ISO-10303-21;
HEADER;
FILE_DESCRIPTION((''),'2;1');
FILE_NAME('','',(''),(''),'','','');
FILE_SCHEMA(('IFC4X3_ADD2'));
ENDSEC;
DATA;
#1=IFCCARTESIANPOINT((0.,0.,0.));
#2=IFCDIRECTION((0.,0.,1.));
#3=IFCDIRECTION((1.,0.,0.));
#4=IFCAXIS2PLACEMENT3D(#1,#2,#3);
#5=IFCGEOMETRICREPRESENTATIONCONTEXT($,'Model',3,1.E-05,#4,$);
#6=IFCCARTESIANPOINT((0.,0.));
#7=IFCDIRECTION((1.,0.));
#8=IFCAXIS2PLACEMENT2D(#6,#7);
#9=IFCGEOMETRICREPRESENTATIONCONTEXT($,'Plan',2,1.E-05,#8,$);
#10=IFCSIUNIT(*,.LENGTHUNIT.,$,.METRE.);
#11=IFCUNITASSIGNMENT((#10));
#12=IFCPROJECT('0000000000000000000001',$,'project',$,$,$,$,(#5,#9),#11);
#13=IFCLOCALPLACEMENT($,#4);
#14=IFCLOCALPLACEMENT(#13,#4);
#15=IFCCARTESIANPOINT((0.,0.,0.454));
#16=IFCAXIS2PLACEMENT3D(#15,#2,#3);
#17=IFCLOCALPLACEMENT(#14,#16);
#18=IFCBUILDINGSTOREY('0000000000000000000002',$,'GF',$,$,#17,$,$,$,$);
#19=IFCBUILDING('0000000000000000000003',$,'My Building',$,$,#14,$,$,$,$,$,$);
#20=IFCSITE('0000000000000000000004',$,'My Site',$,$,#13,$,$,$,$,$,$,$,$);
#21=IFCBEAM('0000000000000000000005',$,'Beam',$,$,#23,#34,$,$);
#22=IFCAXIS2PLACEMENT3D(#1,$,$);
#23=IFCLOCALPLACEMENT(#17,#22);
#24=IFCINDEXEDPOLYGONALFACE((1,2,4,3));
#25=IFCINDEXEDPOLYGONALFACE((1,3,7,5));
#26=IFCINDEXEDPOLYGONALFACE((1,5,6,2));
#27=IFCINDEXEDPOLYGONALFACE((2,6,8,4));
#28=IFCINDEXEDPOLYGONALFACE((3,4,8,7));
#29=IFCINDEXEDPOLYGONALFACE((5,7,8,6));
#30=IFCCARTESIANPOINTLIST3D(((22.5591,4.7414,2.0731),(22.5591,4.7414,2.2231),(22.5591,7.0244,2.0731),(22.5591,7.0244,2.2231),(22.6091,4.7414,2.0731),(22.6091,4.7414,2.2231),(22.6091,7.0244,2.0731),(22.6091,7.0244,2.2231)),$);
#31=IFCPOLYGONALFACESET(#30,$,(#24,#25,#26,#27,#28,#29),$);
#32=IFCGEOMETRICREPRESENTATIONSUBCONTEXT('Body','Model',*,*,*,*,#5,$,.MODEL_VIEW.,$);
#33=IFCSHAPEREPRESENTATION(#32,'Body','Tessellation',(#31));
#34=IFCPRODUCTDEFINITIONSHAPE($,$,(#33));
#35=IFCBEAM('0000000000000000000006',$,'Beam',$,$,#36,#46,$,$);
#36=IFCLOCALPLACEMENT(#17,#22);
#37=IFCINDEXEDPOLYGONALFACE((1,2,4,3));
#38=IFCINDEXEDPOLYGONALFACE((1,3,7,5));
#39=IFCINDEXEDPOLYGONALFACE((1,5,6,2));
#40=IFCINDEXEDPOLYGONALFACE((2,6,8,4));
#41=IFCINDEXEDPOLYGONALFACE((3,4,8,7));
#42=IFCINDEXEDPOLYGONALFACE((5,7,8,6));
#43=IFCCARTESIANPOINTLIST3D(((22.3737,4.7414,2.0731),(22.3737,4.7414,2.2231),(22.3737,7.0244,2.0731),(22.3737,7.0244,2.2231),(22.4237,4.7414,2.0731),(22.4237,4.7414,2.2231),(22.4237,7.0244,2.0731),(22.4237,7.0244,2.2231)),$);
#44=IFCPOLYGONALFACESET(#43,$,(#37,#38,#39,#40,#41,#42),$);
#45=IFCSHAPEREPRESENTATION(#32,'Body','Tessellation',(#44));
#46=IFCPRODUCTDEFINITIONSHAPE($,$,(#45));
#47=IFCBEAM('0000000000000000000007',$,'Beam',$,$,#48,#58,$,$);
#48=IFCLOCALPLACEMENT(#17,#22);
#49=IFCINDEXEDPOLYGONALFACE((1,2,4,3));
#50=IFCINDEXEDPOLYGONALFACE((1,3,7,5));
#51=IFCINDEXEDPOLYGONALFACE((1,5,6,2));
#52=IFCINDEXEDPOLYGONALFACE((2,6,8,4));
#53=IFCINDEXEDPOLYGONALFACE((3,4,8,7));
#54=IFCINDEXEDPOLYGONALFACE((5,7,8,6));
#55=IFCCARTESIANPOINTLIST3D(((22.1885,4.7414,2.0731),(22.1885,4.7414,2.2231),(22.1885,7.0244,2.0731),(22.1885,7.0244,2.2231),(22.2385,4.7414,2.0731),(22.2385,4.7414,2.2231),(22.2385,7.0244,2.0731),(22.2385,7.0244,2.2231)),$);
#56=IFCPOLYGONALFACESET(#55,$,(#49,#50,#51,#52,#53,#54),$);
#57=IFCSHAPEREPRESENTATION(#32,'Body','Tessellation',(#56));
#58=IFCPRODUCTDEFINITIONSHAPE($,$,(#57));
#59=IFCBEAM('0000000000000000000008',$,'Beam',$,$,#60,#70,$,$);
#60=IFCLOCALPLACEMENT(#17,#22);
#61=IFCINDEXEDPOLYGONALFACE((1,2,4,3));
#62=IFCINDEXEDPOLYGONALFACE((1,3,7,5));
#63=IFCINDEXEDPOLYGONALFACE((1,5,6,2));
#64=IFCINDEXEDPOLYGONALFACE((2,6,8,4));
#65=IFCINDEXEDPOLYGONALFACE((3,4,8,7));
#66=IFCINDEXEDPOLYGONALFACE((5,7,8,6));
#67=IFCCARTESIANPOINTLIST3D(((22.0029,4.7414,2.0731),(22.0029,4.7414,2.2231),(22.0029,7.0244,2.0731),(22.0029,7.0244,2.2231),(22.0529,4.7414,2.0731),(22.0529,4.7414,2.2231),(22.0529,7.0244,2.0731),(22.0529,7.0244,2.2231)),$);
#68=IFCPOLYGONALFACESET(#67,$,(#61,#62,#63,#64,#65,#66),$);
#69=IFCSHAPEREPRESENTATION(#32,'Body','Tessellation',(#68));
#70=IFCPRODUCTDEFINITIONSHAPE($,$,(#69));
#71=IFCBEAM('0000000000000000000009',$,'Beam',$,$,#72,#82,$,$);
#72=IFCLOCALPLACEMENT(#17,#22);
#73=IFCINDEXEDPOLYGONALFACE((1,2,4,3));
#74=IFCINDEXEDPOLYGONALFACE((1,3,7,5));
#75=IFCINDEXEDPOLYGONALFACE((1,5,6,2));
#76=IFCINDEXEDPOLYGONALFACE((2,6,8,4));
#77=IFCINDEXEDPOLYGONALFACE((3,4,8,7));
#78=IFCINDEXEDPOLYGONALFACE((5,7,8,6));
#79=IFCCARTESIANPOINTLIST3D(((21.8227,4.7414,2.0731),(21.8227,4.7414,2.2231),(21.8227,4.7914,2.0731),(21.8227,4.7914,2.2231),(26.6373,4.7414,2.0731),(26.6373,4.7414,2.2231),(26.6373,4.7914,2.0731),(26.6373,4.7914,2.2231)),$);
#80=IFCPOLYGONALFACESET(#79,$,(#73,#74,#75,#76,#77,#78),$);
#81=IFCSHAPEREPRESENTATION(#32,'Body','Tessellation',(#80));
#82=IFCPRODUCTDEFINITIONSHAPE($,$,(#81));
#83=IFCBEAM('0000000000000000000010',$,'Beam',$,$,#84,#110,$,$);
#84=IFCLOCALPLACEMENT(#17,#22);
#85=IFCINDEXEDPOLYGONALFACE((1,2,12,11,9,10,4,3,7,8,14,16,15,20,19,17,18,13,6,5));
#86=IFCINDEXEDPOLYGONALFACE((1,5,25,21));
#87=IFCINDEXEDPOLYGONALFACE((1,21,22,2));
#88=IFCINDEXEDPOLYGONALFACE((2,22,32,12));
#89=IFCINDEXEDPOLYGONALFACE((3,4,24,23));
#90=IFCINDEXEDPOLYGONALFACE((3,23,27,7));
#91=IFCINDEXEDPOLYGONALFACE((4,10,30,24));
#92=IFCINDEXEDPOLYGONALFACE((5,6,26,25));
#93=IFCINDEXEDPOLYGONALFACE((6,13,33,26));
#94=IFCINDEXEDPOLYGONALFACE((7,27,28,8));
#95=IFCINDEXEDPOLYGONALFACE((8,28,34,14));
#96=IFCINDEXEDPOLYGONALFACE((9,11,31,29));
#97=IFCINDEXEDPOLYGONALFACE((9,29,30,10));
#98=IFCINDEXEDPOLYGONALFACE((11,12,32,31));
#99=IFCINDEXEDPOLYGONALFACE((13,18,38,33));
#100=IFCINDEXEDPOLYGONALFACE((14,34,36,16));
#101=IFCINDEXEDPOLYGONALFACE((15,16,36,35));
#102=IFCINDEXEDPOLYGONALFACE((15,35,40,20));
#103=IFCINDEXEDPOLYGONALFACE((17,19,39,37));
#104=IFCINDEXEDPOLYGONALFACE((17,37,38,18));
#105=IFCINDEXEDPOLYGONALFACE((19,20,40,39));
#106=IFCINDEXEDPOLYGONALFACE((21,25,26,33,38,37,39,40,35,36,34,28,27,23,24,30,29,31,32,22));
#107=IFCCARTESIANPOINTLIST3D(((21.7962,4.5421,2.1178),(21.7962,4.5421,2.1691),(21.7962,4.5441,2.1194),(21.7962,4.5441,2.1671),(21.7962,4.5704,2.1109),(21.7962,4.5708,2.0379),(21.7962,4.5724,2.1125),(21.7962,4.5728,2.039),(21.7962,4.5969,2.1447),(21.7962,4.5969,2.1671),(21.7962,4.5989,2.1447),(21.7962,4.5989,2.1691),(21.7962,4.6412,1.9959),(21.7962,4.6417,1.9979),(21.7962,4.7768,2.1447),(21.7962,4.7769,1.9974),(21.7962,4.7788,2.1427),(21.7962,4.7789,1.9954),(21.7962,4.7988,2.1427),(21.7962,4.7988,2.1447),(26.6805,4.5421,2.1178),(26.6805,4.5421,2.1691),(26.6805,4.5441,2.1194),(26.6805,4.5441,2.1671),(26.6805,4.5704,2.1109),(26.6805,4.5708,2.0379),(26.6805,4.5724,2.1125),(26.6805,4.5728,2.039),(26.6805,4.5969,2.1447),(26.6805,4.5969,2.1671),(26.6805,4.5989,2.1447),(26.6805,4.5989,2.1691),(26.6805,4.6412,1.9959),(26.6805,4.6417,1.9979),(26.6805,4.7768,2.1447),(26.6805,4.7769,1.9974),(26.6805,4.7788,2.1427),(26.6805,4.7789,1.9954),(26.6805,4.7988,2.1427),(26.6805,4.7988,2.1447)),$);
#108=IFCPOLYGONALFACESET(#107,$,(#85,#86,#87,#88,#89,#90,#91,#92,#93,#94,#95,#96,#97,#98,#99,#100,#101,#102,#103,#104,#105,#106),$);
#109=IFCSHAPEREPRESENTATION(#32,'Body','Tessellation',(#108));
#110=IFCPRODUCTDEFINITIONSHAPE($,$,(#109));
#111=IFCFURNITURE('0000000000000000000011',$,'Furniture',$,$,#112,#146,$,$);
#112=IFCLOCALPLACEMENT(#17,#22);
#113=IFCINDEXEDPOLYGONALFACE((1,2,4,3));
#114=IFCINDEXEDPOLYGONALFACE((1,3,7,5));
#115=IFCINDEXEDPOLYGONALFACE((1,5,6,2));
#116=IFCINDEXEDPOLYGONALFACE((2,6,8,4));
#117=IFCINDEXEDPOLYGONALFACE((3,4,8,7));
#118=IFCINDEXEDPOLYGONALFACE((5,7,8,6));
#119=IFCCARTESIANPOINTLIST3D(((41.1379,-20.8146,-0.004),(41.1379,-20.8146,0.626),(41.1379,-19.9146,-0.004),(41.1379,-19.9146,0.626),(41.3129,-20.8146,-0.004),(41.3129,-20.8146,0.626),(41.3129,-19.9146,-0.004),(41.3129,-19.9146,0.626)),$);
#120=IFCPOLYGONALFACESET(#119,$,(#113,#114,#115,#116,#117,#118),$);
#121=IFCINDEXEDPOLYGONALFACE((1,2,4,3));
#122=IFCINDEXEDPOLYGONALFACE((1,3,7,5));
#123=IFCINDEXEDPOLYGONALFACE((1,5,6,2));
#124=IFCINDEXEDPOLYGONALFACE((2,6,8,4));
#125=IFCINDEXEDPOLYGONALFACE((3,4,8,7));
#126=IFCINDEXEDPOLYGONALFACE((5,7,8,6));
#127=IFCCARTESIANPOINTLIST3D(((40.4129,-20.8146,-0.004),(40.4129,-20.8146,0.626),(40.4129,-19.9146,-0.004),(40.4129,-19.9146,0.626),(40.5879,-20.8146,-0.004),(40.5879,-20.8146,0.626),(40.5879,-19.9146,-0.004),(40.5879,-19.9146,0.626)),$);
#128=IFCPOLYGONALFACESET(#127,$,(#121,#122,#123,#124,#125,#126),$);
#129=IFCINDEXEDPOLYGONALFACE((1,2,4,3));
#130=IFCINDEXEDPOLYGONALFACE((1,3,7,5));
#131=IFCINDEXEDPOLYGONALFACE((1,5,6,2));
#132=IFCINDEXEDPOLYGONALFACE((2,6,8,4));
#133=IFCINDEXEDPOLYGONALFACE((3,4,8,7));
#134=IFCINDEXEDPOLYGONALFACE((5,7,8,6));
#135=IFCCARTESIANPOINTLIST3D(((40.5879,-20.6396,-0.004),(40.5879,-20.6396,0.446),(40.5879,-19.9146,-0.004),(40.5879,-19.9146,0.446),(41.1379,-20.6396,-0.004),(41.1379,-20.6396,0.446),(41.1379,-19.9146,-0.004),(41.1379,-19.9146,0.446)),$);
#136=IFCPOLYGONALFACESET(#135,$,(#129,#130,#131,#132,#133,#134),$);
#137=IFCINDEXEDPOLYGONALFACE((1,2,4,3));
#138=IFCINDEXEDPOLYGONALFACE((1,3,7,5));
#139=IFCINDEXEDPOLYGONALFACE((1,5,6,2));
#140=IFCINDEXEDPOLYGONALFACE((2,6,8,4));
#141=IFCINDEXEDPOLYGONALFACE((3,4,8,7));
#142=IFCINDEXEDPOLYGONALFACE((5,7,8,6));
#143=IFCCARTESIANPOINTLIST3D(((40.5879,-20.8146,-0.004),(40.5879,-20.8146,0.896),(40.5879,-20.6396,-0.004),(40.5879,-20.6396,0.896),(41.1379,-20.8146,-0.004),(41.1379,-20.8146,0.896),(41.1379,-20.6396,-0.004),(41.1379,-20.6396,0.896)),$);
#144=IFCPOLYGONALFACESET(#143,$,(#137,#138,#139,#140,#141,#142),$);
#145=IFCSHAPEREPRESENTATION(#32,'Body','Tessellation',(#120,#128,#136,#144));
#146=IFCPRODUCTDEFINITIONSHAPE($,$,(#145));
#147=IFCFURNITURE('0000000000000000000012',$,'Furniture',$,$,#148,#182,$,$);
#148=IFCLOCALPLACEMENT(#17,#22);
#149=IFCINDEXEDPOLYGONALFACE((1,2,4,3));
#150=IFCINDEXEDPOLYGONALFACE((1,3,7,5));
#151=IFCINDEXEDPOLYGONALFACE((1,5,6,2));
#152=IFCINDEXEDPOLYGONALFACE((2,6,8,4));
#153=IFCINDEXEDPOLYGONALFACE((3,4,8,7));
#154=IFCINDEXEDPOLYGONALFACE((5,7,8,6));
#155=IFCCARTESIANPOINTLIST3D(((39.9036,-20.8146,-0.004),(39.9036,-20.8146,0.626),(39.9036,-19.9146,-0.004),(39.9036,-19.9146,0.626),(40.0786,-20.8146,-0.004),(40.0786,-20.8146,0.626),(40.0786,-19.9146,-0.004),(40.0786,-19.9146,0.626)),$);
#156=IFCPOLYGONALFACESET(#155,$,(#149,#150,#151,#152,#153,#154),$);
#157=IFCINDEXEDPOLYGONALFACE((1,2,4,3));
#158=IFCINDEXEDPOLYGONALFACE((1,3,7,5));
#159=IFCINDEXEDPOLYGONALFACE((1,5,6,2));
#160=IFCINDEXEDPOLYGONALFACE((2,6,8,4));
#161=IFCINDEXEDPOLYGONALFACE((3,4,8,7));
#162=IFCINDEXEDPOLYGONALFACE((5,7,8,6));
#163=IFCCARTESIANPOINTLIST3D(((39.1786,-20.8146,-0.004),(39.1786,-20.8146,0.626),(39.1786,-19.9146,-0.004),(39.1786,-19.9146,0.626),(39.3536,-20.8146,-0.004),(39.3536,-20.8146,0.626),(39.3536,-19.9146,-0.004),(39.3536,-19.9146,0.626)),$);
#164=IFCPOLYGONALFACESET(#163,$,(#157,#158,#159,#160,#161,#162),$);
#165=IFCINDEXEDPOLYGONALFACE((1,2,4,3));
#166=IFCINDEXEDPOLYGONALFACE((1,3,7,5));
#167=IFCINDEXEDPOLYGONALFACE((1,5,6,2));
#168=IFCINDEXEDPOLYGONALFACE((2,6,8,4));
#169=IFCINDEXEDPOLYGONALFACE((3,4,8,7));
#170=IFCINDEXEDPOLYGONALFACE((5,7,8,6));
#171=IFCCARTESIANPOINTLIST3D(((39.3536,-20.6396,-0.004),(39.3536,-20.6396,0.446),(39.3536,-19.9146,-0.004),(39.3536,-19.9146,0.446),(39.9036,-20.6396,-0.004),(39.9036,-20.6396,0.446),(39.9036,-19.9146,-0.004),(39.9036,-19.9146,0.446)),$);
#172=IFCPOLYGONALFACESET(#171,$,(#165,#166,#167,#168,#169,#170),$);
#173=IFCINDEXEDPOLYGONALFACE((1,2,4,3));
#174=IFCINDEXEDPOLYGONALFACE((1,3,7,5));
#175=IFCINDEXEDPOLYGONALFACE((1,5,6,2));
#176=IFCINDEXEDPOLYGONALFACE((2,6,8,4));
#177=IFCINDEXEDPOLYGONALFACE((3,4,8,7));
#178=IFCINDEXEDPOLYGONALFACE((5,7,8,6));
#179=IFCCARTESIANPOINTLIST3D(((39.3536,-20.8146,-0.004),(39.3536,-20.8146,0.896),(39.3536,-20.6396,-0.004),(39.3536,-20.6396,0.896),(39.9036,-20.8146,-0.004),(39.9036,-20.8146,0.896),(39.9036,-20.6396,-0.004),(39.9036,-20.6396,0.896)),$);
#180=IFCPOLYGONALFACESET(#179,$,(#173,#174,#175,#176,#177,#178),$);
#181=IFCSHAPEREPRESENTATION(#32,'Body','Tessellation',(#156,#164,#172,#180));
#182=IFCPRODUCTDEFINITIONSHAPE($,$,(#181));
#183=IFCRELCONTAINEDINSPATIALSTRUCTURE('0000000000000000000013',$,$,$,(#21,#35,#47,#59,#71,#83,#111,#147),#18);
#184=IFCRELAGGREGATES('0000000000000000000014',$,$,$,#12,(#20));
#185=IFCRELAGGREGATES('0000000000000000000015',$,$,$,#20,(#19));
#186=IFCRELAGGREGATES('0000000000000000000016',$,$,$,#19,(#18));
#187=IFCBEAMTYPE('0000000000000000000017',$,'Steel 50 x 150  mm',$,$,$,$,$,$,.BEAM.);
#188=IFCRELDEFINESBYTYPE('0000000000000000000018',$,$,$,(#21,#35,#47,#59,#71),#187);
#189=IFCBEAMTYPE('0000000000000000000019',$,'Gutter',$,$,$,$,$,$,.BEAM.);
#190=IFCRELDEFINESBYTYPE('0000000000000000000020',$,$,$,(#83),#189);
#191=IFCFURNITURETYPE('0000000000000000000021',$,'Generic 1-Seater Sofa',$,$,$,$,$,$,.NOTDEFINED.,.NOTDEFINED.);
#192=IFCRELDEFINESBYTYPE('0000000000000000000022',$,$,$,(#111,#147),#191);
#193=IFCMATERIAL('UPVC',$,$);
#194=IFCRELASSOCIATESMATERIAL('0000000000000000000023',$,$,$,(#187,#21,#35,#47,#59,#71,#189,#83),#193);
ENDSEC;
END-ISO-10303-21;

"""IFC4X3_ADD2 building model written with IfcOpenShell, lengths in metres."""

from ifc_helpers import new_model, entity, si_unit, frame, origin_with_axes, origin_2d_with_axis, place, context, subcontext, project, spatial, line, indexed_curve, rectangle, outline, extrude, shape, source, transform, mapped, material, material_profile, profile_set, profile_usage, type_object, type_shapes, element, save


model = new_model("IFC4X3_ADD2")

# Units and contexts
model_context = context("Model", 3, precision=1e-05, world=origin_with_axes())
plan_context = context("Plan", 2, precision=1e-05, world=origin_2d_with_axis())
body_context_1 = subcontext(model_context, "Body", "Model", "MODEL_VIEW")
body_context_2 = subcontext(plan_context, "Body", "Plan", "PLAN_VIEW")
ifc_project = project(units=[si_unit("LENGTHUNIT", "METRE")], contexts=[model_context, plan_context])

# Site, building, storey
site_placement = place(None, origin_with_axes())
site = spatial("IfcSite", under=ifc_project, at=site_placement, Name="My Site")
building_placement = place(site_placement, origin_with_axes())
building = spatial("IfcBuilding", under=site, at=building_placement, Name="My Building")
storey_placement = place(building_placement, frame((0.0, 0.0, 0.454), z_axis=(0.0, 0.0, 1.0), x_axis=(1.0, 0.0, 0.0)))
storey = spatial("IfcBuildingStorey", under=building, at=storey_placement, Name="GF")

# Beams
ifc_material_1 = material(Name="UPVC")
ifc_material_profile_1 = material_profile(ifc_material_1, rectangle(XDim=0.05, YDim=0.15))
ifc_profile_set_1 = profile_set([ifc_material_profile_1])
beam_type_1 = type_object("IfcBeamType", Name="Steel 50 x 150  mm", PredefinedType="BEAM", material=ifc_profile_set_1)
ifc_profile_usage_1 = profile_usage(ifc_profile_set_1)
beam_1_placement = place(storey_placement, frame((22.5841, 7.0244, 2.1481), z_axis=(0.0, -1.0, 0.0), x_axis=(1.0, 0.0, 0.0)))
element("IfcBeam", 1, at=beam_1_placement, inside=storey, type_object=beam_type_1, material=ifc_profile_usage_1, Name="Beam", context=body_context_1, shape_type="SweptSolid", body=[
    extrude(rectangle(XDim=0.05, YDim=0.15), origin_with_axes(), (0.0, 0.0, 1.0), 2.283),
])
ifc_profile_usage_2 = profile_usage(ifc_profile_set_1)
beam_2_placement = place(storey_placement, frame((22.3987, 7.0244, 2.1481), z_axis=(0.0, -1.0, 0.0), x_axis=(1.0, 0.0, 0.0)))
element("IfcBeam", 2, at=beam_2_placement, inside=storey, type_object=beam_type_1, material=ifc_profile_usage_2, Name="Beam", context=body_context_1, shape_type="SweptSolid", body=[
    extrude(rectangle(XDim=0.05, YDim=0.15), origin_with_axes(), (0.0, 0.0, 1.0), 2.283),
])
ifc_profile_usage_3 = profile_usage(ifc_profile_set_1)
beam_3_placement = place(storey_placement, frame((22.2135, 7.0244, 2.1481), z_axis=(0.0, -1.0, 0.0), x_axis=(1.0, 0.0, 0.0)))
element("IfcBeam", 3, at=beam_3_placement, inside=storey, type_object=beam_type_1, material=ifc_profile_usage_3, Name="Beam", context=body_context_1, shape_type="SweptSolid", body=[
    extrude(rectangle(XDim=0.05, YDim=0.15), origin_with_axes(), (0.0, 0.0, 1.0), 2.283),
])
ifc_profile_usage_4 = profile_usage(ifc_profile_set_1)
beam_4_placement = place(storey_placement, frame((22.0279, 7.0244, 2.1481), z_axis=(0.0, -1.0, 0.0), x_axis=(1.0, 0.0, 0.0)))
element("IfcBeam", 4, at=beam_4_placement, inside=storey, type_object=beam_type_1, material=ifc_profile_usage_4, Name="Beam", context=body_context_1, shape_type="SweptSolid", body=[
    extrude(rectangle(XDim=0.05, YDim=0.15), origin_with_axes(), (0.0, 0.0, 1.0), 2.283),
])
ifc_profile_usage_5 = profile_usage(ifc_profile_set_1)
beam_5_placement = place(storey_placement, frame((21.8227, 4.7664, 2.1481), z_axis=(1.0, 0.0, 0.0), x_axis=(0.0, 1.0, 0.0)))
element("IfcBeam", 5, at=beam_5_placement, inside=storey, type_object=beam_type_1, material=ifc_profile_usage_5, Name="Beam", context=body_context_1, shape_type="SweptSolid", body=[
    extrude(rectangle(XDim=0.05, YDim=0.15), origin_with_axes(), (0.0, 0.0, 1.0), 4.8146),
])
ifc_material_profile_2 = material_profile(ifc_material_1, outline(indexed_curve([(0.0548, 0.1717), (0.002, 0.1717), (0.002, 0.124), (0.0303, 0.1171), (0.0307, 0.0436), (0.0996, 0.0025), (0.2349, 0.002), (0.2347, 0.1494), (0.2567, 0.1494), (0.2567, 0.1474), (0.2367, 0.1474), (0.2369, 0.0), (0.0991, 0.0005), (0.0287, 0.0425), (0.0283, 0.1155), (0.0, 0.1224), (0.0, 0.1737), (0.0568, 0.1737), (0.0568, 0.1494), (0.0548, 0.1494), (0.0548, 0.1717)])))
ifc_profile_set_2 = profile_set([ifc_material_profile_2])
ifc_profile_usage_6 = profile_usage(ifc_profile_set_2)
beam_type_2 = type_object("IfcBeamType", Name="Gutter", PredefinedType="BEAM", material=ifc_profile_set_2)
beam_6_placement = place(storey_placement, frame((21.7962, 4.5421, 1.9954), z_axis=(1.0, 0.0, 0.0), x_axis=(0.0, 1.0, 0.0)))
element("IfcBeam", 6, at=beam_6_placement, inside=storey, type_object=beam_type_2, material=ifc_profile_usage_6, Name="Beam", context=body_context_1, shape_type="SweptSolid", body=[
    extrude(outline(indexed_curve([(0.0548, 0.1717), (0.002, 0.1717), (0.002, 0.124), (0.0303, 0.1171), (0.0307, 0.0436), (0.0996, 0.0025), (0.2349, 0.002), (0.2347, 0.1494), (0.2567, 0.1494), (0.2567, 0.1474), (0.2367, 0.1474), (0.2369, 0.0), (0.0991, 0.0005), (0.0287, 0.0425), (0.0283, 0.1155), (0.0, 0.1224), (0.0, 0.1737), (0.0568, 0.1737), (0.0568, 0.1494), (0.0548, 0.1494), (0.0548, 0.1717)])), origin_with_axes(), (0.0, 0.0, 1.0), 4.8842),
])

# Furniture
furniture_type_1 = type_object("IfcFurnitureType", Name="Generic 1-Seater Sofa", AssemblyPlace="NOTDEFINED", PredefinedType="NOTDEFINED")
shared_shape_1 = source(origin_with_axes(), body_context_1, "Body", "SweptSolid", [
    extrude(outline(indexed_curve([(0.0, 0.0), (0.175, 0.0), (0.175, 0.9), (0.0, 0.9)], segments=[line(4, 1), line(1, 2), line(2, 3), line(3, 4)], self_intersect=False)), frame((-0.45, -0.9, 0.0), z_axis=(0.0, 0.0, 1.0), x_axis=(1.0, 0.0, 0.0)), (0.0, 0.0, 1.0), 0.63),
    extrude(outline(indexed_curve([(0.0, 0.0), (0.175, 0.0), (0.175, 0.9), (0.0, 0.9)], segments=[line(1, 2, 3, 4, 1)])), frame((0.275, -0.9, 0.0), z_axis=(0.0, 0.0, 1.0), x_axis=(1.0, 0.0, 0.0)), (0.0, 0.0, 1.0), 0.63),
    extrude(outline(indexed_curve([(0.175, 0.0), (0.725, 0.0), (0.725, 0.725), (0.175, 0.725)], segments=[line(1, 2, 3, 4, 1)])), frame((-0.45, -0.9, 0.0), z_axis=(0.0, 0.0, 1.0), x_axis=(1.0, 0.0, 0.0)), (0.0, 0.0, 1.0), 0.45),
    extrude(outline(indexed_curve([(0.175, 0.725), (0.725, 0.725), (0.725, 0.9), (0.175, 0.9)], segments=[line(1, 2, 3, 4, 1)])), frame((-0.45, -0.9, 0.0), z_axis=(0.0, 0.0, 1.0), x_axis=(1.0, 0.0, 0.0)), (0.0, 0.0, 1.0), 0.9),
])
shared_shape_2 = source(origin_with_axes(), body_context_2, "Body", "Annotation2D", [
    entity("IfcGeometricCurveSet", [entity("IfcIndexedPolyCurve", entity("IfcCartesianPointList2D", [[0.275, -0.175], [0.275, -0.9], [0.45, -0.9], [0.45, 0.0], [0.275, 0.0], [0.275, -0.9], [-0.275, -0.9], [-0.275, 0.0], [-0.275, -0.175], [0.275, -0.175], [0.275, 0.0], [-0.275, 0.0], [-0.45, 0.0], [-0.45, -0.9], [-0.275, -0.9], [-0.275, -0.175]]))]),
])
type_shapes(furniture_type_1, [shared_shape_1, shared_shape_2])
for number, where, z_axis, x_axis, name in (
    (7, (40.8629, -20.8146, -0.004), (0.0, 0.0, 1.0), (-1.0, 0.0, 0.0), "Furniture"),
    (8, (39.6286, -20.8146, -0.004), (0.0, 0.0, 1.0), (-1.0, 0.0, 0.0), "Furniture"),
):
    element("IfcFurniture", number, at=place(storey_placement, frame(where, z_axis=z_axis, x_axis=x_axis)), inside=storey, type_object=furniture_type_1, Name=name, shapes=[
        shape(body_context_1, "Body", "MappedRepresentation", [mapped(shared_shape_1, transform((0.0, 0.0, 0.0), x_axis=(1.0, 0.0, 0.0), y_axis=(0.0, 1.0, 0.0), z_axis=(0.0, 0.0, 1.0), scale=1.0))]),
        shape(body_context_2, "Body", "MappedRepresentation", [mapped(shared_shape_2, transform((0.0, 0.0, 0.0), x_axis=(1.0, 0.0, 0.0), y_axis=(0.0, 1.0, 0.0), z_axis=(0.0, 0.0, 1.0), scale=1.0))]),
    ])

save(model, "model.ifc")
